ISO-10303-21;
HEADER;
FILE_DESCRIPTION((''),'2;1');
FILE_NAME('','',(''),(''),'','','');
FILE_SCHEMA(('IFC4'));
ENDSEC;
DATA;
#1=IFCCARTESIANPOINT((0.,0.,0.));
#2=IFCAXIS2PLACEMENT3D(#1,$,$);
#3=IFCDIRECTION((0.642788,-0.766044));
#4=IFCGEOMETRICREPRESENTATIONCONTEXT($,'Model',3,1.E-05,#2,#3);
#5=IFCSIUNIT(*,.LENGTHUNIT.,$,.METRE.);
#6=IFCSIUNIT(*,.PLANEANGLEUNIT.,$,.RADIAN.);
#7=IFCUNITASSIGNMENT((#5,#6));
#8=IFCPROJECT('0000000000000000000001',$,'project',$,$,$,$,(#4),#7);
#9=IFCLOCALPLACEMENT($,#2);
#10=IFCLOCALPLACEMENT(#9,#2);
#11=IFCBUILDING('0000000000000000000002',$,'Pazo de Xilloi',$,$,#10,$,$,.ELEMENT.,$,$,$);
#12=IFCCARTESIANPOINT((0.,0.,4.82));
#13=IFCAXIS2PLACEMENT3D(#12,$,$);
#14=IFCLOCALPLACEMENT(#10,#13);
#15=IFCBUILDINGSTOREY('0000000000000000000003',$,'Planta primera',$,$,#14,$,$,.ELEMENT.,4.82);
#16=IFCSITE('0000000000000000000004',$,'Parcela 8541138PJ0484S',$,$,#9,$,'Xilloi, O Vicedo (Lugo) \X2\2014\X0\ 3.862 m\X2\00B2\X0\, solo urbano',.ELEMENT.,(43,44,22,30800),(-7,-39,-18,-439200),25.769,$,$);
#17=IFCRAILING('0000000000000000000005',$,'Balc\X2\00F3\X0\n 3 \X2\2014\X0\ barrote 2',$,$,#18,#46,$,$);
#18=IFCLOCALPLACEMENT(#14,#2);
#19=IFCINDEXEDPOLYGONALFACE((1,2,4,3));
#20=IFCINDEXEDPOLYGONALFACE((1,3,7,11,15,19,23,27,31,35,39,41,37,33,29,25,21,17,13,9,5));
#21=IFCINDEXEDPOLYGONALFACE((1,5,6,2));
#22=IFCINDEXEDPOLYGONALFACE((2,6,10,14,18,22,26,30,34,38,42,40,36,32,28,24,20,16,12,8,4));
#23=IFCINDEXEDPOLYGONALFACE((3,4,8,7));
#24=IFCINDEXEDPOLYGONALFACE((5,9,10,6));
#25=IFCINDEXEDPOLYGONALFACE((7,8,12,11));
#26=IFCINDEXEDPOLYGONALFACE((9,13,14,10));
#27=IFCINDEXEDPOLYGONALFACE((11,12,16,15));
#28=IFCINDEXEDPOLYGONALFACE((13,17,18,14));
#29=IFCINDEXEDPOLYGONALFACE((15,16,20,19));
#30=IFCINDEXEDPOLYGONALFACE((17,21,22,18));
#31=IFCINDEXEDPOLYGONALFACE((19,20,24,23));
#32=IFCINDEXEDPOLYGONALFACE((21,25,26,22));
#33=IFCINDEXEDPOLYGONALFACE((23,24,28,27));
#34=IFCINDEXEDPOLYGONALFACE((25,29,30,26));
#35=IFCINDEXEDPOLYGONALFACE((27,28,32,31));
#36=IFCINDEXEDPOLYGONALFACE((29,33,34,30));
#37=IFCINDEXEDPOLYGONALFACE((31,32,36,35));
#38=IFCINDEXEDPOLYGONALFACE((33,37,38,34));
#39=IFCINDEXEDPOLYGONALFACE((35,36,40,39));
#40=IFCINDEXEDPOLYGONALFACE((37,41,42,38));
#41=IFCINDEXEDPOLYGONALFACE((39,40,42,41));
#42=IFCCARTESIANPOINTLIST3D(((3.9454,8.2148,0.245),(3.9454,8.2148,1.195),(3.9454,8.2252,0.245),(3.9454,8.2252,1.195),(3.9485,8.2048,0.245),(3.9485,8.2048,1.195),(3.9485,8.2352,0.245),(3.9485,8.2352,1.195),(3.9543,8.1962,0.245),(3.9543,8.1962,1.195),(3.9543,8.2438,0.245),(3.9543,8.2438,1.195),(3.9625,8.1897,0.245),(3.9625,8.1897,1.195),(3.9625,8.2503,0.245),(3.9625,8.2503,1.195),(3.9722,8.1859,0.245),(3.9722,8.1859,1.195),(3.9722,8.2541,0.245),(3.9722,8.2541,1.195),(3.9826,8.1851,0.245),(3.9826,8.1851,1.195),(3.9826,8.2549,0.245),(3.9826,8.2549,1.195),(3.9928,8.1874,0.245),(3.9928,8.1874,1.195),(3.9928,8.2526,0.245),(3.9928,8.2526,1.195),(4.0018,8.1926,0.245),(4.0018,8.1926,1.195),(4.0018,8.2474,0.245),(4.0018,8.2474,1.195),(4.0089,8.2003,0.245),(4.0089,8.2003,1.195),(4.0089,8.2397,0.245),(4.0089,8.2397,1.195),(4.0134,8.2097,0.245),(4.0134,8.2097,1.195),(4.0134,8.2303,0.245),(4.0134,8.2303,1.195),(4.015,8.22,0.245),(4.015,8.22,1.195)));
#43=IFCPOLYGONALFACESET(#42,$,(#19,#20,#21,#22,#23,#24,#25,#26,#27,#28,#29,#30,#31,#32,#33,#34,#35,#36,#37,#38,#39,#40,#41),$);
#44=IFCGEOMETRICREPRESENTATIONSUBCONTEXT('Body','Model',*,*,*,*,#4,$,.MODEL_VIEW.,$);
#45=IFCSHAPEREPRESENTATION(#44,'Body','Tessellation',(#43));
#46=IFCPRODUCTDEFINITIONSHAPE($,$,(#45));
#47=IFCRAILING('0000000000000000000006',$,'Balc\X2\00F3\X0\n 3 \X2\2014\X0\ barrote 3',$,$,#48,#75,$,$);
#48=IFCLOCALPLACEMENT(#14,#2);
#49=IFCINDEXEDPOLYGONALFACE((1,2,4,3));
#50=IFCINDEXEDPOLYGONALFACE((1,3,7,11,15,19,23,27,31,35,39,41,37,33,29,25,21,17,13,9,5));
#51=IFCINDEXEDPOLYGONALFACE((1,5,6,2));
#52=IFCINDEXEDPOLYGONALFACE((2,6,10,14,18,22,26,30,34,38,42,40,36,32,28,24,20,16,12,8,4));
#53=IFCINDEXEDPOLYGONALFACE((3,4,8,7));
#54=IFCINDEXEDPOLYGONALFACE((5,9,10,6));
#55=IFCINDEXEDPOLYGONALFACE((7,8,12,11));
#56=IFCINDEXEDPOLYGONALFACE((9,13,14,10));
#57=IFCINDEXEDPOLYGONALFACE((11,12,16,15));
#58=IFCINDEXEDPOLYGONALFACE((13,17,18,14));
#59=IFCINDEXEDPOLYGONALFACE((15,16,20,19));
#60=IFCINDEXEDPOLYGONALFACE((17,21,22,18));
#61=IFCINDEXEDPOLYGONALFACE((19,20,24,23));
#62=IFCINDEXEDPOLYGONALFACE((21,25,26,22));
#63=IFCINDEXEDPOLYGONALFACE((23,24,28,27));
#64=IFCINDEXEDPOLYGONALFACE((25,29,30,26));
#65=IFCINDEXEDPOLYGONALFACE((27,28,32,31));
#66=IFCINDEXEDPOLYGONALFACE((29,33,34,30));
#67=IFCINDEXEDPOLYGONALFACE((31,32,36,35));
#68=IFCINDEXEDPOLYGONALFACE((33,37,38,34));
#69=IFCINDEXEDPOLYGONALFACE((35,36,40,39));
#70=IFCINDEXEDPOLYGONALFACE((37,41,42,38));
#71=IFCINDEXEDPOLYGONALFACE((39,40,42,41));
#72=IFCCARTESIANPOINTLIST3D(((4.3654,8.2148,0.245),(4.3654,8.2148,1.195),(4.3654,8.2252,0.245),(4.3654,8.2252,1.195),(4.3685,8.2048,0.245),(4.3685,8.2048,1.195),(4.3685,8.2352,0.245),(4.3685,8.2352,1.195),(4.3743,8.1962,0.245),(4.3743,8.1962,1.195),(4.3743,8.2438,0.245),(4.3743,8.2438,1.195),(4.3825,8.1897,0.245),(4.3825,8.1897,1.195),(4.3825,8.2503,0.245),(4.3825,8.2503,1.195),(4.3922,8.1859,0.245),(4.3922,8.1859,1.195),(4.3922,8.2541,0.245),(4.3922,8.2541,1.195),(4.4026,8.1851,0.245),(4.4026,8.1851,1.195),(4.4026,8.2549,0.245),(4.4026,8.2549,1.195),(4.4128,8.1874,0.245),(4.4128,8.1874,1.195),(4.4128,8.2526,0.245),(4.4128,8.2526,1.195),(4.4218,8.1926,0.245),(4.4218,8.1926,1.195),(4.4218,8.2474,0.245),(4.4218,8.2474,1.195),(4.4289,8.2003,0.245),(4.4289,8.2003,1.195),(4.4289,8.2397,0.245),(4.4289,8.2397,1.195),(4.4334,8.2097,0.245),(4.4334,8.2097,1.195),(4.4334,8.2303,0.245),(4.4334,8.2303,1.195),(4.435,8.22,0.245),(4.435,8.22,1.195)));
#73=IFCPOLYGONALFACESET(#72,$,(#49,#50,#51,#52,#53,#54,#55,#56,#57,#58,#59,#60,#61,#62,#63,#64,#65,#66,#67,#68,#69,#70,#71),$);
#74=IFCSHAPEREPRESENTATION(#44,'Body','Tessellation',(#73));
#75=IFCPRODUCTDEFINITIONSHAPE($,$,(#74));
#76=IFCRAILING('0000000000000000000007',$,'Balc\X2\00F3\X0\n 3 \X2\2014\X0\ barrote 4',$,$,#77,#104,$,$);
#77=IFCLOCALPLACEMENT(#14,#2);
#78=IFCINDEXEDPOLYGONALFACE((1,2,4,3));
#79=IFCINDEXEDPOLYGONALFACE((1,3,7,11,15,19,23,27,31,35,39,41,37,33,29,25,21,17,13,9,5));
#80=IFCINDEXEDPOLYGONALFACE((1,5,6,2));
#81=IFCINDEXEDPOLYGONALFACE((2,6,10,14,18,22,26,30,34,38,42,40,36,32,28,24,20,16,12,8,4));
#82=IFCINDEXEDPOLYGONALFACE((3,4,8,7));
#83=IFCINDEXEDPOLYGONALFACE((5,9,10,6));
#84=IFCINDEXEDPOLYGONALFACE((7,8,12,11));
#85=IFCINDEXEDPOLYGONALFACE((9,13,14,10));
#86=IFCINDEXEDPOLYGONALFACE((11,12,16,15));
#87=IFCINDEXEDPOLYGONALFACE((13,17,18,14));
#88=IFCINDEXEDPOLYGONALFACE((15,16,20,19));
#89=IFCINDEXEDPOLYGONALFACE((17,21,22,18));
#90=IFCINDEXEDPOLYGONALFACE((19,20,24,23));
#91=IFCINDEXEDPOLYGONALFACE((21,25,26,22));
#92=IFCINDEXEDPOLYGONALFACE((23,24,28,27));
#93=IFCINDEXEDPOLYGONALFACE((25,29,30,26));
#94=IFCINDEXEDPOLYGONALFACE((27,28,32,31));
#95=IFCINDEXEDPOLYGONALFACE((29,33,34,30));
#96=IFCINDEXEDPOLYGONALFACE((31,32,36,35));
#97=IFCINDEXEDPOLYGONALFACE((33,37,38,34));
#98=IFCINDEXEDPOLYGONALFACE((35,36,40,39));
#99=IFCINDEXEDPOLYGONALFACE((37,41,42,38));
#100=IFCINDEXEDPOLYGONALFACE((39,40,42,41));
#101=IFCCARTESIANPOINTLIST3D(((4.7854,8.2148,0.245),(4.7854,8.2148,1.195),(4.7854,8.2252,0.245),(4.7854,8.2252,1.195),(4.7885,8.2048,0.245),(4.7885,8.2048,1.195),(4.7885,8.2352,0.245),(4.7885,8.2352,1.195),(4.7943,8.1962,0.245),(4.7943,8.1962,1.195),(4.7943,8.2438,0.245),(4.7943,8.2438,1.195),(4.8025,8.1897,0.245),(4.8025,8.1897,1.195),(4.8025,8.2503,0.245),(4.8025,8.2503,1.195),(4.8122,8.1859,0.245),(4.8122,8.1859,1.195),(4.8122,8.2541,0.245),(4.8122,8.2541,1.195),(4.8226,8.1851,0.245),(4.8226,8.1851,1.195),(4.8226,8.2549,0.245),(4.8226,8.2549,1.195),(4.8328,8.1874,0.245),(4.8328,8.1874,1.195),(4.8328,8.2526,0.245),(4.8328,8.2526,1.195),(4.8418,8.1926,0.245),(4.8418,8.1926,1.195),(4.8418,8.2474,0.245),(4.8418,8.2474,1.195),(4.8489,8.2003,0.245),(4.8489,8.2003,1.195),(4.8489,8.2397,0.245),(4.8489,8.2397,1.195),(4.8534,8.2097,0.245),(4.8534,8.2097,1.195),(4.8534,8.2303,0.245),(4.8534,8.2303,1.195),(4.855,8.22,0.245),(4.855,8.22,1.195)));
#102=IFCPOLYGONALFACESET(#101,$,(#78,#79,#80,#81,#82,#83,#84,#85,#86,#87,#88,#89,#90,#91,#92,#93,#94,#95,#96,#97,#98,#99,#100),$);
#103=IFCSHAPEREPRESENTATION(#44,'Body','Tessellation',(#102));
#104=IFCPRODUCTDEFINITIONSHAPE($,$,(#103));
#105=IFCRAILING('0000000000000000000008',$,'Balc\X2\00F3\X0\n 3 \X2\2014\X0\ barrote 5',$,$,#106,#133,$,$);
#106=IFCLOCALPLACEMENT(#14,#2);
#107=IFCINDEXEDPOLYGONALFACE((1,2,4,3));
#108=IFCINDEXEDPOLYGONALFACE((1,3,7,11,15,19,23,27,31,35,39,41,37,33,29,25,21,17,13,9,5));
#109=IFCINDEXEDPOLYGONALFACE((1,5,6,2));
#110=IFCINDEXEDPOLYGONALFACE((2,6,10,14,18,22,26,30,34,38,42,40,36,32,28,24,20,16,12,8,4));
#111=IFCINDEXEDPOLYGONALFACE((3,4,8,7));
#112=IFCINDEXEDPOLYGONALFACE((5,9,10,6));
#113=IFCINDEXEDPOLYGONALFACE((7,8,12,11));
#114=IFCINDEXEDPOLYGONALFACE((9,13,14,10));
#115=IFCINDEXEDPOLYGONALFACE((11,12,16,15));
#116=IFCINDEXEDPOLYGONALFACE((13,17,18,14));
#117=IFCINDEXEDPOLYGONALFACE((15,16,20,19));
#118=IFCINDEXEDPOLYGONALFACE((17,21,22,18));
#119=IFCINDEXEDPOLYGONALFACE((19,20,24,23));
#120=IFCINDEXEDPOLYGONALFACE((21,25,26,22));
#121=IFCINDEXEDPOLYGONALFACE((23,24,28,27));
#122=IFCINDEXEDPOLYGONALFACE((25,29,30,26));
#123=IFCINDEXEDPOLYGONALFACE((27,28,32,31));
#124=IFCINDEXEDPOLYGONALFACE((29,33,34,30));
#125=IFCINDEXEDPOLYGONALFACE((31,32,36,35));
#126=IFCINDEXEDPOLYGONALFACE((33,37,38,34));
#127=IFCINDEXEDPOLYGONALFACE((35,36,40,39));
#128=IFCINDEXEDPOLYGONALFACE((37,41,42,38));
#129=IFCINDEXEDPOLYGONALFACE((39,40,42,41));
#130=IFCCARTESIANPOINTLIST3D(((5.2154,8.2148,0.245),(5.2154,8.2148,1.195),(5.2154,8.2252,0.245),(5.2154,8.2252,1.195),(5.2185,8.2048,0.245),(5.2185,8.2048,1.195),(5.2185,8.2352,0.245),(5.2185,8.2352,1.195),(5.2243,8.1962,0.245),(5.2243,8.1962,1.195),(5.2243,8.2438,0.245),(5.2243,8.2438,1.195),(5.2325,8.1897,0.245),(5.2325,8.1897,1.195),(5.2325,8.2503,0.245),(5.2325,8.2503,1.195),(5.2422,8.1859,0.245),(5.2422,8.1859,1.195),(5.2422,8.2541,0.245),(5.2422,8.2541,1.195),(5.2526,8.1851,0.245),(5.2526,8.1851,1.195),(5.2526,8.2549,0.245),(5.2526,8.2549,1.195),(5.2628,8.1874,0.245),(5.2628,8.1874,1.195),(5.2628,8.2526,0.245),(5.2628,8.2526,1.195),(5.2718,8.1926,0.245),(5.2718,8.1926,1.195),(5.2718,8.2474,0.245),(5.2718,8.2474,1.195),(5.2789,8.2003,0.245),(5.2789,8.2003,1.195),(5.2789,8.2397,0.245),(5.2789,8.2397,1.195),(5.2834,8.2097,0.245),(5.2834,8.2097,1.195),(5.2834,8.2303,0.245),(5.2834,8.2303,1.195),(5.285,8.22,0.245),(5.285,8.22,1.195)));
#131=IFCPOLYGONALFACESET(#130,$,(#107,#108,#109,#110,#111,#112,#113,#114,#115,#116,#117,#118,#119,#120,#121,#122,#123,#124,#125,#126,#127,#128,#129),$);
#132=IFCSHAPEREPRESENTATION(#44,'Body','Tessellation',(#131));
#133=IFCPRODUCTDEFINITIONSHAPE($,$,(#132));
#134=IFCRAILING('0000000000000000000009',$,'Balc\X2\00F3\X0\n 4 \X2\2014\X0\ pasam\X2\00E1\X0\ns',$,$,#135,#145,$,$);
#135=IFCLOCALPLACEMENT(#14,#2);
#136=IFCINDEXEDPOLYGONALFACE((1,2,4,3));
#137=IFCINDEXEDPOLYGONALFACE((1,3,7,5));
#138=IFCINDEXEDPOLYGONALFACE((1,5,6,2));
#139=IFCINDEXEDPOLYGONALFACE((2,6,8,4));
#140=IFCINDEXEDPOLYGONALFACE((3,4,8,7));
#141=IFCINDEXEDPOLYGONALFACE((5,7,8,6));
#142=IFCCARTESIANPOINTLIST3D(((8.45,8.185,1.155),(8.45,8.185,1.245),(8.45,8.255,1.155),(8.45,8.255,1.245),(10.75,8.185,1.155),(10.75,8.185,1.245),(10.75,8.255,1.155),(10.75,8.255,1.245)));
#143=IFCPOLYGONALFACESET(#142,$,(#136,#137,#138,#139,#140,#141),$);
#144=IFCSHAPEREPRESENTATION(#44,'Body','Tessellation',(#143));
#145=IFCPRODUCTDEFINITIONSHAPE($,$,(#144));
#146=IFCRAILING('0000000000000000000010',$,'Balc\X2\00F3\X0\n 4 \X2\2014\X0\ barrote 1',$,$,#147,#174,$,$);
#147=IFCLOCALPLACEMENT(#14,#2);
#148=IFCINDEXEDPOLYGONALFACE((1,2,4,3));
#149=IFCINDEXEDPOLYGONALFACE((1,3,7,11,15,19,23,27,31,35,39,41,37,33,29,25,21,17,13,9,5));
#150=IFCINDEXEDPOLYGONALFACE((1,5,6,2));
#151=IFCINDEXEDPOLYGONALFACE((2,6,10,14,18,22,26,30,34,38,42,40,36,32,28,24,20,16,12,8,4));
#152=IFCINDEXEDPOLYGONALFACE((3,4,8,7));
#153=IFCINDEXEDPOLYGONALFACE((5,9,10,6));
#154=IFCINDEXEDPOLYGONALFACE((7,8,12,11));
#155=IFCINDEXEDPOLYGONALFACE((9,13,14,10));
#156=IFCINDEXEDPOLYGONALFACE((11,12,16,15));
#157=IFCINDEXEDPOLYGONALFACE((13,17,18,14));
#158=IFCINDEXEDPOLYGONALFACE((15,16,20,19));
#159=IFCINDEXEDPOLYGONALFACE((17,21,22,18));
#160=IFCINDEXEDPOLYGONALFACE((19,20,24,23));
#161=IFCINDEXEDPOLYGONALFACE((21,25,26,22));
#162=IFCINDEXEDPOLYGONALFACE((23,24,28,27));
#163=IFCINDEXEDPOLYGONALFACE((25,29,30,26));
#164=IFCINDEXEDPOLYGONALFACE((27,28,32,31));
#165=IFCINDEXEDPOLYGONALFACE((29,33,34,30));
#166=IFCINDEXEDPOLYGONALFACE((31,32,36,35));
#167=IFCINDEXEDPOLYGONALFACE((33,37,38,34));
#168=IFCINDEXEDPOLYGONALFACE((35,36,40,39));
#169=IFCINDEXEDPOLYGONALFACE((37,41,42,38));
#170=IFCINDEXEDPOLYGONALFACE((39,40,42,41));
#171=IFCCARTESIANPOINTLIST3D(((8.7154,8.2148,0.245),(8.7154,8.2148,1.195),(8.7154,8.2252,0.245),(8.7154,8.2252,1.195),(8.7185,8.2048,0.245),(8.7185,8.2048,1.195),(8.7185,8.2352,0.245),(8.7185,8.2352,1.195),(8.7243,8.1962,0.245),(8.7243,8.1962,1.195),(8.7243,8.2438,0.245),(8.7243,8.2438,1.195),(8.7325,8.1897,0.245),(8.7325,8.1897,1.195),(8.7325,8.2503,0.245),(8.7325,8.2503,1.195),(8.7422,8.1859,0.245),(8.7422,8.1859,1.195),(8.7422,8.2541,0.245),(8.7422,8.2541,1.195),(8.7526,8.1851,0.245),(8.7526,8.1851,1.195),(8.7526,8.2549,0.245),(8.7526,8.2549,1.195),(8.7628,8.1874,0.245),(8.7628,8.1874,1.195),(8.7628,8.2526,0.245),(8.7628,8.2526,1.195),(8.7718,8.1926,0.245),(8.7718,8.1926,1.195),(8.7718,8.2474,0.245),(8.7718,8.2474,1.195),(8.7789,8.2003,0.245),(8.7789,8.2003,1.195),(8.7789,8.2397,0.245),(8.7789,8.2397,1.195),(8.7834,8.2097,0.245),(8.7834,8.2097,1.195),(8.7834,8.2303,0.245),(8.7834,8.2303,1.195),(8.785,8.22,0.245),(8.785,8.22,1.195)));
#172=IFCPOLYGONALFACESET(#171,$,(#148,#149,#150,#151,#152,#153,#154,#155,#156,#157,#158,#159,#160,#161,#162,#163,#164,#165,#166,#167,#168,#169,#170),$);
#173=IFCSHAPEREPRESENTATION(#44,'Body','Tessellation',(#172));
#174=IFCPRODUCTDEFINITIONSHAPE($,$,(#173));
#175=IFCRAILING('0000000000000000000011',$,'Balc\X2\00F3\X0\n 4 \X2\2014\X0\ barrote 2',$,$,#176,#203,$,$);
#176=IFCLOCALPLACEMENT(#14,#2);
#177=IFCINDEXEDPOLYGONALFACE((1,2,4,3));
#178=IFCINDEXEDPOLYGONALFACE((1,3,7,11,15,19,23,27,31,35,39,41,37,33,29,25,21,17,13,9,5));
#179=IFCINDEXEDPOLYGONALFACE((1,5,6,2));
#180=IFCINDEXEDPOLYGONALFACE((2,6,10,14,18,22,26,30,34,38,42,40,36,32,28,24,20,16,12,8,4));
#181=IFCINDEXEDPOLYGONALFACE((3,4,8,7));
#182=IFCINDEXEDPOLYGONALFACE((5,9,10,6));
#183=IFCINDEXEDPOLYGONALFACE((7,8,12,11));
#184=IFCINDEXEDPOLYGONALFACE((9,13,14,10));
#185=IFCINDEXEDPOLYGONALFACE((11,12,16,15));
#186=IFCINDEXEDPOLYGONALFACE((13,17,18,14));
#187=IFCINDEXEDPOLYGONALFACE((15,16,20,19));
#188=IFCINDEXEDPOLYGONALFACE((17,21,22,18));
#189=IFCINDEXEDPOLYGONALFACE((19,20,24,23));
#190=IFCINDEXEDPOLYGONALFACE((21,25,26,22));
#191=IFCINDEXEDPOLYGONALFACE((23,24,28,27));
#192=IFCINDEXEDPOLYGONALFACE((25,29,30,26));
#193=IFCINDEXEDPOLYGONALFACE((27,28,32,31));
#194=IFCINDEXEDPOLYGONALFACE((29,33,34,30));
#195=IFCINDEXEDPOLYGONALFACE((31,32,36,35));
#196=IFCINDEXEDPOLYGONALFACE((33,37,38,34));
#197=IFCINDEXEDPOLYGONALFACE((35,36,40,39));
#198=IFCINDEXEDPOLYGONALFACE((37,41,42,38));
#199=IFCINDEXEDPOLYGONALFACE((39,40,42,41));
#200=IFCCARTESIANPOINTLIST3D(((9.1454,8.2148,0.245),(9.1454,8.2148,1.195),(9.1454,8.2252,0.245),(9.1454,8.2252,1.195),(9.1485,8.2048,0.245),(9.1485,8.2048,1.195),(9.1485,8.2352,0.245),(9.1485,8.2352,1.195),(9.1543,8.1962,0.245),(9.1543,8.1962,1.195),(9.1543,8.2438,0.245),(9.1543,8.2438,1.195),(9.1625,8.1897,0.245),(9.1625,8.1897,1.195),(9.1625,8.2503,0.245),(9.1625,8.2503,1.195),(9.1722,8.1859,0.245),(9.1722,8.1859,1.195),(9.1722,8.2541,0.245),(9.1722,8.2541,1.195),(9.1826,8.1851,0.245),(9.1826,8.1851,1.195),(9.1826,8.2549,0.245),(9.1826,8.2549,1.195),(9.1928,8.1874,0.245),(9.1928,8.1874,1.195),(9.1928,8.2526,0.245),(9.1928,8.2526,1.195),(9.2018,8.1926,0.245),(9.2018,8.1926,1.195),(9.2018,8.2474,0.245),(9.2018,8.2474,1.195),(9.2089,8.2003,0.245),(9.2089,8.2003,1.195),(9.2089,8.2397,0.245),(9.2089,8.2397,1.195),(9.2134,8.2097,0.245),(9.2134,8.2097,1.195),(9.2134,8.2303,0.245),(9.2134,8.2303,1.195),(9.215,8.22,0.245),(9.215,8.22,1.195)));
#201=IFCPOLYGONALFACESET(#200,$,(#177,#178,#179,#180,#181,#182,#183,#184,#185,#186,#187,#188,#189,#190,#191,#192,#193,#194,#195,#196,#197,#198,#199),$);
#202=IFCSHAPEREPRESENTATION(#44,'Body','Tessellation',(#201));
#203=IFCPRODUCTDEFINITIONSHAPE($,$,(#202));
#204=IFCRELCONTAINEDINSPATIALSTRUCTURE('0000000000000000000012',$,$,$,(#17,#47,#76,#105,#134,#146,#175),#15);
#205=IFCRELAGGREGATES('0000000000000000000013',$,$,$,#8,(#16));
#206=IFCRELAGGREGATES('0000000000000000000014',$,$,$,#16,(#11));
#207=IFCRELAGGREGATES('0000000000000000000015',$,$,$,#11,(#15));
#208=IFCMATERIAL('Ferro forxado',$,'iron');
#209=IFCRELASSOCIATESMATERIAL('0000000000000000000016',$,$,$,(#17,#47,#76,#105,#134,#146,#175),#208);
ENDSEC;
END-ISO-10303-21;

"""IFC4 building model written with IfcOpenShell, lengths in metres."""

from ifc_helpers import new_model, si_unit, direction, frame, origin, origin_2d, place, context, subcontext, project, spatial, rectangle, circle, extrude, material, element, save


model = new_model("IFC4")

# Units and contexts
model_context = context("Model", 3, precision=1e-05, world=origin(), true_north=direction((0.642788, -0.766044)))
body_context = subcontext(model_context, "Body", "Model", "MODEL_VIEW")
ifc_project = project(units=[si_unit("LENGTHUNIT", "METRE"), si_unit("PLANEANGLEUNIT", "RADIAN")], contexts=[model_context])

# Site, building, storey
site_placement = place(None, origin())
site = spatial("IfcSite", under=ifc_project, at=site_placement, Name="Parcela 8541138PJ0484S", LongName="Xilloi, O Vicedo (Lugo) — 3.862 m², solo urbano", CompositionType="ELEMENT", RefLatitude=(43, 44, 22, 30800), RefLongitude=(-7, -39, -18, -439200), RefElevation=25.769)
building_placement = place(site_placement, origin())
building = spatial("IfcBuilding", under=site, at=building_placement, Name="Pazo de Xilloi", CompositionType="ELEMENT")
storey_placement = place(building_placement, frame((0.0, 0.0, 4.82)))
storey = spatial("IfcBuildingStorey", under=building, at=storey_placement, Name="Planta primera", CompositionType="ELEMENT", Elevation=4.82)

# Railings
ifc_material_1 = material(Name="Ferro forxado", Category="iron")
for number, where, name in (
    (1, (3.98, 8.22, 0.72), "Balcón 3 — barrote 2"),
    (2, (4.4, 8.22, 0.72), "Balcón 3 — barrote 3"),
    (3, (4.82, 8.22, 0.72), "Balcón 3 — barrote 4"),
    (4, (5.25, 8.22, 0.72), "Balcón 3 — barrote 5"),
):
    element("IfcRailing", number, at=place(storey_placement, frame(where)), inside=storey, material=ifc_material_1, Name=name, context=body_context, shape_type="SweptSolid", body=[
        extrude(circle(Radius=0.035, at=origin_2d()), frame((0.0, 0.0, -0.475)), (0.0, 0.0, 1.0), 0.95),
    ])
railing_1_placement = place(storey_placement, frame((9.6, 8.22, 1.2)))
element("IfcRailing", 5, at=railing_1_placement, inside=storey, material=ifc_material_1, Name="Balcón 4 — pasamáns", context=body_context, shape_type="SweptSolid", body=[
    extrude(rectangle(XDim=2.3, YDim=0.07, at=origin_2d()), frame((0.0, 0.0, -0.045)), (0.0, 0.0, 1.0), 0.09),
])
for number, where, name in (
    (6, (8.75, 8.22, 0.72), "Balcón 4 — barrote 1"),
    (7, (9.18, 8.22, 0.72), "Balcón 4 — barrote 2"),
):
    element("IfcRailing", number, at=place(storey_placement, frame(where)), inside=storey, material=ifc_material_1, Name=name, context=body_context, shape_type="SweptSolid", body=[
        extrude(circle(Radius=0.035, at=origin_2d()), frame((0.0, 0.0, -0.475)), (0.0, 0.0, 1.0), 0.95),
    ])

save(model, "model.ifc")
